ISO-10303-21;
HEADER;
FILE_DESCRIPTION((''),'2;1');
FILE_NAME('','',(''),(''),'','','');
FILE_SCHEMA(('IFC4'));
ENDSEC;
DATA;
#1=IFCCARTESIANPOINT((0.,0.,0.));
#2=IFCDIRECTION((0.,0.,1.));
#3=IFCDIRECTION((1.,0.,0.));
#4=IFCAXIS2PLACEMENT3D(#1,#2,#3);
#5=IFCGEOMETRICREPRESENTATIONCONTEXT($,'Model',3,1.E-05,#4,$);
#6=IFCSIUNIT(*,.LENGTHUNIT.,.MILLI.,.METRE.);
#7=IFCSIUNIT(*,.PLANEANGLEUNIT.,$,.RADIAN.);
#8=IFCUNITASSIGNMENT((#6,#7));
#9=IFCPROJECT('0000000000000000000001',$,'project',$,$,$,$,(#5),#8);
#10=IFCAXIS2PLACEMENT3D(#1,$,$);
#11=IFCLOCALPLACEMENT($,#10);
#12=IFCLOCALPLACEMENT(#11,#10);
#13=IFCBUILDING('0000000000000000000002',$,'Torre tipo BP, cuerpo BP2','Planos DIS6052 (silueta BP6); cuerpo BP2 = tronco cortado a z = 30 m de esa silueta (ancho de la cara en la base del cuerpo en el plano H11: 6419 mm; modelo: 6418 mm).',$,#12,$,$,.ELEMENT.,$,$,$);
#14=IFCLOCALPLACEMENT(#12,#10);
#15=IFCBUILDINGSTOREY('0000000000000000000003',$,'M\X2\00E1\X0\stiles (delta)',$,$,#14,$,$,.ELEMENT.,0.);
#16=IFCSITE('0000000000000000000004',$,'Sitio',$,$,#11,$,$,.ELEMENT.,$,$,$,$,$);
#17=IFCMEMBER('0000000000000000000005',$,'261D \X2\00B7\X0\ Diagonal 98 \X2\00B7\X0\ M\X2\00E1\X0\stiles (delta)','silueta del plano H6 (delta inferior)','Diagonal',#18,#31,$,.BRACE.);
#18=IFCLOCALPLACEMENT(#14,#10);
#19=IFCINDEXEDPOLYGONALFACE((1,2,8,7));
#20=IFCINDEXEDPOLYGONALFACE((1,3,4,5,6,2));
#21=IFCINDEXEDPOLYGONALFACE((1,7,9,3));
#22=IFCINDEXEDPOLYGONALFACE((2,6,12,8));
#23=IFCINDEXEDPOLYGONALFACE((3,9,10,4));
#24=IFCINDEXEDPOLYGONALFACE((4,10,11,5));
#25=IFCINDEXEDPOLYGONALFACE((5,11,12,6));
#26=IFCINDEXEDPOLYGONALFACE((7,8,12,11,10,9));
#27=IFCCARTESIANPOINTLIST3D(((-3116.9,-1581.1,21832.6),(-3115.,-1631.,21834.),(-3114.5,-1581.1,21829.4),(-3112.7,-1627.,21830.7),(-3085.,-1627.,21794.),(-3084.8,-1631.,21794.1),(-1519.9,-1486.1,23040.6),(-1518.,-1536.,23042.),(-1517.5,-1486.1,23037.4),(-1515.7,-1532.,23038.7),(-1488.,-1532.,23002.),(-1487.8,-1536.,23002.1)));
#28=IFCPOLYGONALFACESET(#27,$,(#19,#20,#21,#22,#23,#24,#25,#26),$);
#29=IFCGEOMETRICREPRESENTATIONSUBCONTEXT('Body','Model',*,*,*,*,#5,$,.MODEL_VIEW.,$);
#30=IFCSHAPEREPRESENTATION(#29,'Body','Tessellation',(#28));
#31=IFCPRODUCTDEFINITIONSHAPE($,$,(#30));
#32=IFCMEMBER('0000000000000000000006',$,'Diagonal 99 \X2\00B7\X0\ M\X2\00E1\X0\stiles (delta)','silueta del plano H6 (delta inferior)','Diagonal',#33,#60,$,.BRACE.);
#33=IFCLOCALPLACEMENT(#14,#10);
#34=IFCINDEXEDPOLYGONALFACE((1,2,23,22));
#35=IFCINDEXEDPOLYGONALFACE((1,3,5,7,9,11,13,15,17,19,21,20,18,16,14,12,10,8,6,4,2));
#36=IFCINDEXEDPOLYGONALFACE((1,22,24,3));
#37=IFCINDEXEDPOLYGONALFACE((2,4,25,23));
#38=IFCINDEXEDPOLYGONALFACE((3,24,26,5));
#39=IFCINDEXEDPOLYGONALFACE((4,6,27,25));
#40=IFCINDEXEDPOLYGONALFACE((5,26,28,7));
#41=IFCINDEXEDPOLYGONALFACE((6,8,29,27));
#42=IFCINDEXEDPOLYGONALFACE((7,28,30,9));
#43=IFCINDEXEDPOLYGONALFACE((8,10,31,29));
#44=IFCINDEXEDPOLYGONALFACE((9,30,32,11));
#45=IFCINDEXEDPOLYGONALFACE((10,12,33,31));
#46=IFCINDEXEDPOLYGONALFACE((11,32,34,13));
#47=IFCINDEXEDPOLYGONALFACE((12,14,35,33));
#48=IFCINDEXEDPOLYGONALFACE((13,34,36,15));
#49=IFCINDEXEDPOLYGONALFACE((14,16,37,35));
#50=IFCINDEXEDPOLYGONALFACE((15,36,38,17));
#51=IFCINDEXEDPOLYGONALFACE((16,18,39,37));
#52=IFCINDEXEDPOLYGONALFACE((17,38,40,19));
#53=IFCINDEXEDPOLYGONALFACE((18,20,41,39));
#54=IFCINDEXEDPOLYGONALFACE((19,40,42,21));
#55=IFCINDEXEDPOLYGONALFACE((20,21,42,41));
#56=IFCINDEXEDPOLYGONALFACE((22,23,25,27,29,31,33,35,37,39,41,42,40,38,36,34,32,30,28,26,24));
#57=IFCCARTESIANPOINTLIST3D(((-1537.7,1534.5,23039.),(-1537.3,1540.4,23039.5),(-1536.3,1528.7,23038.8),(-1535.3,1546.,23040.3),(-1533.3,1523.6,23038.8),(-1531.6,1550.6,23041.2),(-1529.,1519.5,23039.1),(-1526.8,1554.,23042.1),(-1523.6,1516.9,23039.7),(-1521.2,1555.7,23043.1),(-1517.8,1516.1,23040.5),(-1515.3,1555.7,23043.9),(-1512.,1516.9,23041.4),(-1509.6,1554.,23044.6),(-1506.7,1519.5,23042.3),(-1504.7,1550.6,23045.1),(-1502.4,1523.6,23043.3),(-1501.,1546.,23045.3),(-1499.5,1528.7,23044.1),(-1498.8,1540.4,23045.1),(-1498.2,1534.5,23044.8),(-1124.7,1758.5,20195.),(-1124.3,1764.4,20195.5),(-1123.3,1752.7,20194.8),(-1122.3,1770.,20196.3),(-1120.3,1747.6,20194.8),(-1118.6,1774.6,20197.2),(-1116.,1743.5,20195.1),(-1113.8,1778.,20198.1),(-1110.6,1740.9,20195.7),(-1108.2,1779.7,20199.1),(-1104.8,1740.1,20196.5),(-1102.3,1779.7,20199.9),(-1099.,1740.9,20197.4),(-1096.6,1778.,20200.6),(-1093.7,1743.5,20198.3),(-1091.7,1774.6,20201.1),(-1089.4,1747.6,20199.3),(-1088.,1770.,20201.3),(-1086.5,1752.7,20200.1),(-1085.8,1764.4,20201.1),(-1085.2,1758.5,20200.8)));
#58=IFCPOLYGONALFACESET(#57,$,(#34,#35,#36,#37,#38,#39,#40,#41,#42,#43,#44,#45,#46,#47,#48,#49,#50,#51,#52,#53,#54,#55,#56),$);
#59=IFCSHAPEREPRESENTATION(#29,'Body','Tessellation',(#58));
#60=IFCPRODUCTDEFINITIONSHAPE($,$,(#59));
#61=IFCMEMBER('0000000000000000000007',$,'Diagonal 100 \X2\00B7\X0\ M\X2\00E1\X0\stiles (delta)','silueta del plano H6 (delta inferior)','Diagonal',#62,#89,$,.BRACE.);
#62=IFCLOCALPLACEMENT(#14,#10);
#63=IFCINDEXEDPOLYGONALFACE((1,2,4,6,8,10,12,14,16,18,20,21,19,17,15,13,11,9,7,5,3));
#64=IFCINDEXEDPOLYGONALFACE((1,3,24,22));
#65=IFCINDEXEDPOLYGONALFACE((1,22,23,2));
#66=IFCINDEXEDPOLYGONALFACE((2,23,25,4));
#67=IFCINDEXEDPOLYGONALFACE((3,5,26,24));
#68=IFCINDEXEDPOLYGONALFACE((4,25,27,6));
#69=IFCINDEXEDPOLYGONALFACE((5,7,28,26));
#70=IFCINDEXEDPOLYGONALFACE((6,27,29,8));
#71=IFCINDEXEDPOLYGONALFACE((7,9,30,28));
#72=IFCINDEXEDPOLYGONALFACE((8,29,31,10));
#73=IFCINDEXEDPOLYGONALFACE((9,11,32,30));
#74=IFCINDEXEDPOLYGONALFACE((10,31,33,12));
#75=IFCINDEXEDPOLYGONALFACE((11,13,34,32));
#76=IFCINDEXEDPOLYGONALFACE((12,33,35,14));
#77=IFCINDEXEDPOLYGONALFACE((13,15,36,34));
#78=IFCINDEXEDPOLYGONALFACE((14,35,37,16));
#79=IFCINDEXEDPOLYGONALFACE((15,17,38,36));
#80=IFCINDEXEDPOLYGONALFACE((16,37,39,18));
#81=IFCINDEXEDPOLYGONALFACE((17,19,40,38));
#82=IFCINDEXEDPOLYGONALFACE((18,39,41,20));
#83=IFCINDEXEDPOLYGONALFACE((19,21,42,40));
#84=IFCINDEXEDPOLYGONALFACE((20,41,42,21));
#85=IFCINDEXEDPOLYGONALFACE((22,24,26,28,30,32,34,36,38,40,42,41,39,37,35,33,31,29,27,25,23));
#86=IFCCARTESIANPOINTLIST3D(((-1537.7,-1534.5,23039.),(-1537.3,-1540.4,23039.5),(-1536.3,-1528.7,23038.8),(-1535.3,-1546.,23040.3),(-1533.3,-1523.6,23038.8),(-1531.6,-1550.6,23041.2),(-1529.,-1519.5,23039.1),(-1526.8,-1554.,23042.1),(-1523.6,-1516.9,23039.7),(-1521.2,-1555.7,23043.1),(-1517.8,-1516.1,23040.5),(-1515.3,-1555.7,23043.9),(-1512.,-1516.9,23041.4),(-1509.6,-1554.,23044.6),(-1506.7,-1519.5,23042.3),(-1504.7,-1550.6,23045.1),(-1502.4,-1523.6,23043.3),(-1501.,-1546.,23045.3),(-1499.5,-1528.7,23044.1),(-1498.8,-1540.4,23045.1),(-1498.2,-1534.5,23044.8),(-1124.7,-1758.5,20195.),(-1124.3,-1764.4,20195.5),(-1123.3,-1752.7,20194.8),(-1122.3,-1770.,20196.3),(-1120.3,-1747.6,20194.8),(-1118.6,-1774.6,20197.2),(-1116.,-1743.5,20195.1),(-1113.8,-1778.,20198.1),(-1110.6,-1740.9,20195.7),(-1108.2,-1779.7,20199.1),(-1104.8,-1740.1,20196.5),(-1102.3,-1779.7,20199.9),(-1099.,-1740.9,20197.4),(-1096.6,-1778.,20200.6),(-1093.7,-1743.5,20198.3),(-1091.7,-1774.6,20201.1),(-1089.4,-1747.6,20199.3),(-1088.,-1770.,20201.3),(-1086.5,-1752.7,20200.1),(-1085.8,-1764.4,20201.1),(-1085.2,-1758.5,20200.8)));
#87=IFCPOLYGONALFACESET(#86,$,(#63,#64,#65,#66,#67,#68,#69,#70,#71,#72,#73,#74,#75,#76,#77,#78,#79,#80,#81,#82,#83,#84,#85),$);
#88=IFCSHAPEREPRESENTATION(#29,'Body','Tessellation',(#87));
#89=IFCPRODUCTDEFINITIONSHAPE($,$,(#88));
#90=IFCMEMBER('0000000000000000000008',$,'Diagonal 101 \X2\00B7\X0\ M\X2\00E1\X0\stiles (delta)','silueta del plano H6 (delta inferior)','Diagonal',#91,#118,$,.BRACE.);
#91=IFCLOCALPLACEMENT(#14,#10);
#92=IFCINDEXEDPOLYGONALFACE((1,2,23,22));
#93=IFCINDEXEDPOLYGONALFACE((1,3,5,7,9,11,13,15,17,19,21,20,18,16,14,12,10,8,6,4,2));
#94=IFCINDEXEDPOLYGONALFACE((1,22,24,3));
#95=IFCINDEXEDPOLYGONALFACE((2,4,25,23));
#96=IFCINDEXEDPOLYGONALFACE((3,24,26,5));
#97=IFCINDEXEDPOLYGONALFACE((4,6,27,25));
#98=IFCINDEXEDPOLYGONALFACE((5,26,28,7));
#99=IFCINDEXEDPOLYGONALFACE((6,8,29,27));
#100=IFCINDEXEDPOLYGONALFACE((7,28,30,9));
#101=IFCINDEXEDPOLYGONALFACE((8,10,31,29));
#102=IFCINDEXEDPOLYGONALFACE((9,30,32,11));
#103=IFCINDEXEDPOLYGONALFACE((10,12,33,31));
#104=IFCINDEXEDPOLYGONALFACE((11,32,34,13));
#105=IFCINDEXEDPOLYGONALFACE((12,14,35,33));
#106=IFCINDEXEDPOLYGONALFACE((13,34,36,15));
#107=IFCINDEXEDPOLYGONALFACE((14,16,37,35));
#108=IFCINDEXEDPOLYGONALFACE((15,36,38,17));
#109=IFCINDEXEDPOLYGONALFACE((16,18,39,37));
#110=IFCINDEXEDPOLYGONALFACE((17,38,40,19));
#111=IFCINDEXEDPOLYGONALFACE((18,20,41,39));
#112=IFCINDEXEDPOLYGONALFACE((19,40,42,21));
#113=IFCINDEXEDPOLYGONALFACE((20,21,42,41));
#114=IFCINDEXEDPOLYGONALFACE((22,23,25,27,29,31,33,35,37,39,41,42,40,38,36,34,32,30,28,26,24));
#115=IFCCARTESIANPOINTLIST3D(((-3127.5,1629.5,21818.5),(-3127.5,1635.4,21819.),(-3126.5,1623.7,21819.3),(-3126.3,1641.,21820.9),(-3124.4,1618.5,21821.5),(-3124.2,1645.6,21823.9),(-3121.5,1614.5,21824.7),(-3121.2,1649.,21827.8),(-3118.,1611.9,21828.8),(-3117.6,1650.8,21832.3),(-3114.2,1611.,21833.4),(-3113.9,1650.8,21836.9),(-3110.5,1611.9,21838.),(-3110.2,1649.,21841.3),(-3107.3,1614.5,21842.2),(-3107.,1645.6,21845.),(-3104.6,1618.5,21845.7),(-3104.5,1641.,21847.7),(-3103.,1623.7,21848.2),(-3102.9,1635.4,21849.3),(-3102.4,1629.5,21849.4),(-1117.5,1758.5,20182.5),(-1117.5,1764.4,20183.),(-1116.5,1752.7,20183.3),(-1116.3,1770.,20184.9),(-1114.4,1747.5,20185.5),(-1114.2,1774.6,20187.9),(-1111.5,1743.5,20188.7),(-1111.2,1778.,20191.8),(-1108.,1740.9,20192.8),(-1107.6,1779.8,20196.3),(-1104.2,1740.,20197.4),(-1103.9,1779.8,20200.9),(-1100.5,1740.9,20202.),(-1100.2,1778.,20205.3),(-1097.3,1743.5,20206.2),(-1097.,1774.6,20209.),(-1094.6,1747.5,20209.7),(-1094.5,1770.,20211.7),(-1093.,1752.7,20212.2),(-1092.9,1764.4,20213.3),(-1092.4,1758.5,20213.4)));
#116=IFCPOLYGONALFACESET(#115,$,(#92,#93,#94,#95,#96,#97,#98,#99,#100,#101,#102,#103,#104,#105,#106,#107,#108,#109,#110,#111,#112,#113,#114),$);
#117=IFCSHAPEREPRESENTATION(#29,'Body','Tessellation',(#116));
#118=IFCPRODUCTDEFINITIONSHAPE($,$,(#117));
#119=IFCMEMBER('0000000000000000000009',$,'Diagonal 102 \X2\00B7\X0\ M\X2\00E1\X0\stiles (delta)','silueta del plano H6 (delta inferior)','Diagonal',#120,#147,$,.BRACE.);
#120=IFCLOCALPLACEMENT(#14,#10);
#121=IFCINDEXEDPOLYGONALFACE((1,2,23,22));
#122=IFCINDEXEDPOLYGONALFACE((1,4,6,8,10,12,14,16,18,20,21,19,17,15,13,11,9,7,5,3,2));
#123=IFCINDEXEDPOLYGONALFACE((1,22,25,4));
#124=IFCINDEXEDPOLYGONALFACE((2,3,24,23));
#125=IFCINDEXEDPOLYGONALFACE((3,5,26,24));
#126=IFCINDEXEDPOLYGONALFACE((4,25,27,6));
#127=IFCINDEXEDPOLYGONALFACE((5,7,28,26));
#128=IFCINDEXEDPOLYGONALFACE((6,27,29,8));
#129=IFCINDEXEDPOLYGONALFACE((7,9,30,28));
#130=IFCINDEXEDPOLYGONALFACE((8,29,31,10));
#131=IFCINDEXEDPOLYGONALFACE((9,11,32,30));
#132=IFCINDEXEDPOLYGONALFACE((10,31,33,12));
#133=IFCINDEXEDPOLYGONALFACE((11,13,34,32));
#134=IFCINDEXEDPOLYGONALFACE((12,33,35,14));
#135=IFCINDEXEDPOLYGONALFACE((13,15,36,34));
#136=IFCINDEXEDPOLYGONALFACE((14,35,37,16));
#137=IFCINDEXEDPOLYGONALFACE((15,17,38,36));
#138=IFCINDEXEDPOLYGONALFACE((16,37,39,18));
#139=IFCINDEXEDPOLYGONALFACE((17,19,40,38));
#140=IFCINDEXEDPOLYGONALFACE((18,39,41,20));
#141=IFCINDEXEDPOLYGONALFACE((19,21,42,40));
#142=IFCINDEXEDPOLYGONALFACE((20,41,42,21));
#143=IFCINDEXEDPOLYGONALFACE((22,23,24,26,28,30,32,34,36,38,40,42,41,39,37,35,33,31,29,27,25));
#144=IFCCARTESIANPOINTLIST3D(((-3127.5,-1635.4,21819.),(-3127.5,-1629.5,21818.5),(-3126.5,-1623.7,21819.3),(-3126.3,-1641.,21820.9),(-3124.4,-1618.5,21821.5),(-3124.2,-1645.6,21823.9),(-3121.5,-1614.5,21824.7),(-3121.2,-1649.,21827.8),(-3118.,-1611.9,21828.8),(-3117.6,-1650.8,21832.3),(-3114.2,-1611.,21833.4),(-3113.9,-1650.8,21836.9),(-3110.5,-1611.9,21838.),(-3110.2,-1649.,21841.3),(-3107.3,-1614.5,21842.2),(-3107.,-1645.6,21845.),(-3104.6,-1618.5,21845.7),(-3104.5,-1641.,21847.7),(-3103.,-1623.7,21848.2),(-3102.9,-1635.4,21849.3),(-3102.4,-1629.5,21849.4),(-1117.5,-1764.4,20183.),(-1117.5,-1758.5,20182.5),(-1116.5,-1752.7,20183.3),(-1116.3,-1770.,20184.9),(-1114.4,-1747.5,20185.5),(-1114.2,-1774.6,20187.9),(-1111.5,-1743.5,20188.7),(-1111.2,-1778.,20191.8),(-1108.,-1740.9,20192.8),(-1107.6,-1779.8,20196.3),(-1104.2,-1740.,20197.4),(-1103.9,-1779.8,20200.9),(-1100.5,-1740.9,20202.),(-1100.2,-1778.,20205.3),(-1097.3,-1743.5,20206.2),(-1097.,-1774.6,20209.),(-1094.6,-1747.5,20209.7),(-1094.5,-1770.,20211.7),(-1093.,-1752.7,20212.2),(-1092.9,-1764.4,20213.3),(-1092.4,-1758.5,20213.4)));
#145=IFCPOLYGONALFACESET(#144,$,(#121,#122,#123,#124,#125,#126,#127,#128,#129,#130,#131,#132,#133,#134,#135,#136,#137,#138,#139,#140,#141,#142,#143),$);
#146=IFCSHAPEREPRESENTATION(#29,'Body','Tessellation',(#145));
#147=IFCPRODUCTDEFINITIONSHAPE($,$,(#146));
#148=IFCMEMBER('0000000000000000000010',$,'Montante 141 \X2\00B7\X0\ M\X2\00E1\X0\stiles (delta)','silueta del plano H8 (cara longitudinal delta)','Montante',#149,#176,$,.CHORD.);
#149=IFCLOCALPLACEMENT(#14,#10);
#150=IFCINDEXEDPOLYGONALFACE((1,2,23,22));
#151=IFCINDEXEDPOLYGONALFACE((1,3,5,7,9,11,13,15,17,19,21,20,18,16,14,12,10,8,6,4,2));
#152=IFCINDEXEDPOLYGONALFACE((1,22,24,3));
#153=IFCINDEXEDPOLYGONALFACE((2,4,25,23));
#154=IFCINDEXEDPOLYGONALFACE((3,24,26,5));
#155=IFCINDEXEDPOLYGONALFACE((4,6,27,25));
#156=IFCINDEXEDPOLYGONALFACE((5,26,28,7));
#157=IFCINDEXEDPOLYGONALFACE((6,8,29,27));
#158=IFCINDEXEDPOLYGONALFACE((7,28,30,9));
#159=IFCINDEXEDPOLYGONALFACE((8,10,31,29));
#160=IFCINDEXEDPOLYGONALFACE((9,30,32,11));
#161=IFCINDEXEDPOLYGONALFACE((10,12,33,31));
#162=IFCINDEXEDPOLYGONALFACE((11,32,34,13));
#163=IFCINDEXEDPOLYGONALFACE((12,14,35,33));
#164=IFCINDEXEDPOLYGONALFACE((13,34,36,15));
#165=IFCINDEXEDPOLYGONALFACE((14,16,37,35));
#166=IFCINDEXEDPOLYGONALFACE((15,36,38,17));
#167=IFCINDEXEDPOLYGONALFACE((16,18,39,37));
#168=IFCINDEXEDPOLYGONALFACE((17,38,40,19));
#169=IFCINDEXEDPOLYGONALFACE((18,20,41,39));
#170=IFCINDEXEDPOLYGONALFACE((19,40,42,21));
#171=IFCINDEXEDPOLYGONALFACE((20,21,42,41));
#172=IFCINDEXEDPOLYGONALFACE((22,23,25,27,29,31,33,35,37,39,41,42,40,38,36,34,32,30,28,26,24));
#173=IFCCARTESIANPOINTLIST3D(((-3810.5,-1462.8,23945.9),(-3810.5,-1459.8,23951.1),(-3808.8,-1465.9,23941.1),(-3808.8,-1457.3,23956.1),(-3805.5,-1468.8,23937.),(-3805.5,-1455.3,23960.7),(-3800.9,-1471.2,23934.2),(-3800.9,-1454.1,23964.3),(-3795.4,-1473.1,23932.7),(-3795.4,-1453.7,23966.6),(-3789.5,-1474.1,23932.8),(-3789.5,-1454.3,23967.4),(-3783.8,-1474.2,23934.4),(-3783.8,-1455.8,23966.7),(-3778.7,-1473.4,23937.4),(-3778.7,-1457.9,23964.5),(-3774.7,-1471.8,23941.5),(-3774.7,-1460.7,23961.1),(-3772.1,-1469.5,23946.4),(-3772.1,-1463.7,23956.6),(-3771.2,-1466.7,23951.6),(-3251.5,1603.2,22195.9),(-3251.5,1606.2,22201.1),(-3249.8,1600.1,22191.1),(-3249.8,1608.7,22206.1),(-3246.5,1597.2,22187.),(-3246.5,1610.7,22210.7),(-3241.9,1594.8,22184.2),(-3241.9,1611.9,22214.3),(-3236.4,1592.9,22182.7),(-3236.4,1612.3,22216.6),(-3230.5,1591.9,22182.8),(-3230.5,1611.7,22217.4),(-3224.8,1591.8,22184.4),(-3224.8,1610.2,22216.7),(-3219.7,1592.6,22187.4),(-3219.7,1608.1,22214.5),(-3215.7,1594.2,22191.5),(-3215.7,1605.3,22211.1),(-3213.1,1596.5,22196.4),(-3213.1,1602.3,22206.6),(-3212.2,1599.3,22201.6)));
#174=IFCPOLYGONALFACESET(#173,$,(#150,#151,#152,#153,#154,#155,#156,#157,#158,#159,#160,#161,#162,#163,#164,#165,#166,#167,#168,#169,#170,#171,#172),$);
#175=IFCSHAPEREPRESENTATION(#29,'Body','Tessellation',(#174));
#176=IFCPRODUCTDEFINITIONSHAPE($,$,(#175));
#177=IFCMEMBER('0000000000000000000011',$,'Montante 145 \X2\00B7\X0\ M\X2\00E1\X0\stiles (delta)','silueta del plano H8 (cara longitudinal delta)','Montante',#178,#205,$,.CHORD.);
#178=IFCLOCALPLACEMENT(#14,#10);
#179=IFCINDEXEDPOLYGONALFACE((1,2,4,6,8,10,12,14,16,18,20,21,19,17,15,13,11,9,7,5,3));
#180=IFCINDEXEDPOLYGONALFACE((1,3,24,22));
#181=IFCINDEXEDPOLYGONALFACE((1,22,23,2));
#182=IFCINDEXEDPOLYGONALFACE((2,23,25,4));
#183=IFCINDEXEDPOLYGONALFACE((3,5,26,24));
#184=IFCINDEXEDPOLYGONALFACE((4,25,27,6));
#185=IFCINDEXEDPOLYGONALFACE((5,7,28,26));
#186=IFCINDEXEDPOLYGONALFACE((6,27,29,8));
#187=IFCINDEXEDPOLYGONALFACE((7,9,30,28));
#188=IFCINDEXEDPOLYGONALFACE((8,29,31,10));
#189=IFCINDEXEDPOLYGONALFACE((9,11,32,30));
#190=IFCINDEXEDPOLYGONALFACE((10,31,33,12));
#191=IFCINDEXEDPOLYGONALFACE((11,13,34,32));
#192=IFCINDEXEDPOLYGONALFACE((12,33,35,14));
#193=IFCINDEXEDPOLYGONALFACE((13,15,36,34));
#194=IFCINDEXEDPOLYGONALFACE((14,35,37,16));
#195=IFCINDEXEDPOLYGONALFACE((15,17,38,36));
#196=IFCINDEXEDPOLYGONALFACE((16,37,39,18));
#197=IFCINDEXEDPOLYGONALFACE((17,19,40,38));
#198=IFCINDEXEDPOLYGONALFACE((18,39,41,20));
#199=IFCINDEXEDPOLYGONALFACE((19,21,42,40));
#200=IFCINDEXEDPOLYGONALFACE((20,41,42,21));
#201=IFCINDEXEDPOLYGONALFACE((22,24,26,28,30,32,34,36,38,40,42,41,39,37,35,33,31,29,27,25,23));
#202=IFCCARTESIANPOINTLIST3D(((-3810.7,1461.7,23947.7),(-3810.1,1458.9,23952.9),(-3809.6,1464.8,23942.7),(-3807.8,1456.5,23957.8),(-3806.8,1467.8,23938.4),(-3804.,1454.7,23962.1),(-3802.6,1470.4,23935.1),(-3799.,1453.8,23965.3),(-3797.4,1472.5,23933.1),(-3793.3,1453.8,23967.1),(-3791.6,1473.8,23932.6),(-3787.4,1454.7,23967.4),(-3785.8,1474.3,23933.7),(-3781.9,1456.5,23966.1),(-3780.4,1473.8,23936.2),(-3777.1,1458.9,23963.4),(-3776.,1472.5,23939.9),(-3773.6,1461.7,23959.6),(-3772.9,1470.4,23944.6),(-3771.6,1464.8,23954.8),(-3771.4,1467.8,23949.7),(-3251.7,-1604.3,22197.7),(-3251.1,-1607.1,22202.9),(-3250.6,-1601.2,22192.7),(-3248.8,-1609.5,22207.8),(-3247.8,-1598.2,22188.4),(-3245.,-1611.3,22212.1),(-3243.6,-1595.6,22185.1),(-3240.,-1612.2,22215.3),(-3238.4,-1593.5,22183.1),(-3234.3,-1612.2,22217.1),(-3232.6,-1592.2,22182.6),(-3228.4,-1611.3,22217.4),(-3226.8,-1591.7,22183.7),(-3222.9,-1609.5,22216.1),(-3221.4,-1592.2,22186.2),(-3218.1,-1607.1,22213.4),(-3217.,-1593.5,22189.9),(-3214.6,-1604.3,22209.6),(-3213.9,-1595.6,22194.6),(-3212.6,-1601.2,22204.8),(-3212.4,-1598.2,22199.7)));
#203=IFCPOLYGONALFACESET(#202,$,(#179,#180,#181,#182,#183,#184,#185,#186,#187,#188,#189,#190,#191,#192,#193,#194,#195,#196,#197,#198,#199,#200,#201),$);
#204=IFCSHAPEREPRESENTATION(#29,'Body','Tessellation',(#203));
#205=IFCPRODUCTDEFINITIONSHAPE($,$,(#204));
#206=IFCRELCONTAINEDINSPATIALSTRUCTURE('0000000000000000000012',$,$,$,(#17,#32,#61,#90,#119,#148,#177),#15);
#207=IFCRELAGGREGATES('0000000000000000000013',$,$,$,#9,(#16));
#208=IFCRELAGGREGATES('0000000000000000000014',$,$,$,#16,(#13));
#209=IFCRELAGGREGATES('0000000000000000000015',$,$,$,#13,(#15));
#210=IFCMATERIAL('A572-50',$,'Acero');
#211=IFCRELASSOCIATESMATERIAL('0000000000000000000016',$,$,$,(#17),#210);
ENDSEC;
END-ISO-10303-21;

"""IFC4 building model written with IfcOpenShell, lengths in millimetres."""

from ifc_helpers import new_model, si_unit, frame, frame_2d, origin, origin_with_axes, place, context, subcontext, project, spatial, circle, l_section, extrude, material, element, save


model = new_model("IFC4")

# Units and contexts
model_context = context("Model", 3, precision=1e-05, world=origin_with_axes())
body_context = subcontext(model_context, "Body", "Model", "MODEL_VIEW")
ifc_project = project(units=[si_unit("LENGTHUNIT", "METRE", prefix="MILLI"), si_unit("PLANEANGLEUNIT", "RADIAN")], contexts=[model_context])

# Site, building, storey
site_placement = place(None, origin())
site = spatial("IfcSite", under=ifc_project, at=site_placement, Name="Sitio", CompositionType="ELEMENT")
building_placement = place(site_placement, origin())
building = spatial("IfcBuilding", under=site, at=building_placement, Name="Torre tipo BP, cuerpo BP2", Description="Planos DIS6052 (silueta BP6); cuerpo BP2 = tronco cortado a z = 30 m de esa silueta (ancho de la cara en la base del cuerpo en el plano H11: 6419 mm; modelo: 6418 mm).", CompositionType="ELEMENT")
storey_placement = place(building_placement, origin())
storey = spatial("IfcBuildingStorey", under=building, at=storey_placement, Name="Mástiles (delta)", CompositionType="ELEMENT", Elevation=0.0)

# Members
ifc_material = material(Name="A572-50", Category="Acero")
for number, where, z_axis, x_axis, name in (
    (1, (-1518.0, -1536.0, 23042.0), (-0.79664, -0.047389, -0.602593), (-0.037795, 0.998876, -0.028589), "261D · Diagonal 98 · Mástiles (delta)"),
):
    element("IfcMember", number, at=place(storey_placement, frame(where, z_axis=z_axis, x_axis=x_axis)), inside=storey, material=ifc_material, Name=name, Description="silueta del plano H6 (delta inferior)", ObjectType="Diagonal", PredefinedType="BRACE", context=body_context, shape_type="SweptSolid", body=[
        extrude(l_section(Depth=50.0, Width=50.0, Thickness=4.0, at=frame_2d((25.0, 25.0))), None, (0.0, 0.0, 1.0), 2004.7),
    ])
for number, where, z_axis, x_axis, name in (
    (2, (-1518.0, 1536.0, 23042.0), (0.143276, 0.077709, -0.986627), (0.011168, -0.996976, -0.076902), "Diagonal 99 · Mástiles (delta)"),
    (3, (-1518.0, -1536.0, 23042.0), (0.143276, -0.077709, -0.986627), (0.011168, 0.996976, -0.076902), "Diagonal 100 · Mástiles (delta)"),
):
    element("IfcMember", number, at=place(storey_placement, frame(where, z_axis=z_axis, x_axis=x_axis)), inside=storey, Name=name, Description="silueta del plano H6 (delta inferior)", ObjectType="Diagonal", PredefinedType="BRACE", context=body_context, shape_type="SweptSolid", body=[
        extrude(circle(Radius=20.0), None, (0.0, 0.0, 1.0), 2882.5),
    ])
for number, where, z_axis, x_axis, name in (
    (4, (-1105.0, 1760.0, 20198.0), (-0.774612, -0.049714, 0.63048), (0.038557, -0.998764, -0.031382), "Diagonal 101 · Mástiles (delta)"),
    (5, (-1105.0, -1760.0, 20198.0), (-0.774612, 0.049714, 0.63048), (0.038557, 0.998764, -0.031382), "Diagonal 102 · Mástiles (delta)"),
):
    element("IfcMember", number, at=place(storey_placement, frame(where, z_axis=z_axis, x_axis=x_axis)), inside=storey, Name=name, Description="silueta del plano H6 (delta inferior)", ObjectType="Diagonal", PredefinedType="BRACE", context=body_context, shape_type="SweptSolid", body=[
        extrude(circle(Radius=20.0), None, (0.0, 0.0, 1.0), 2594.8),
    ])
for number, where, z_axis, x_axis, name in (
    (6, (-3791.0, -1464.0, 23950.0), (0.156396, 0.8578, -0.489612), (0.987694, -0.135828, 0.077527), "Montante 141 · Mástiles (delta)"),
    (7, (-3791.0, 1464.0, 23950.0), (0.156396, -0.8578, -0.489612), (0.261013, 0.513984, -0.817125), "Montante 145 · Mástiles (delta)"),
):
    element("IfcMember", number, at=place(storey_placement, frame(where, z_axis=z_axis, x_axis=x_axis)), inside=storey, Name=name, Description="silueta del plano H8 (cara longitudinal delta)", ObjectType="Montante", PredefinedType="CHORD", context=body_context, shape_type="SweptSolid", body=[
        extrude(circle(Radius=20.0), None, (0.0, 0.0, 1.0), 3574.3),
    ])

save(model, "model.ifc")
